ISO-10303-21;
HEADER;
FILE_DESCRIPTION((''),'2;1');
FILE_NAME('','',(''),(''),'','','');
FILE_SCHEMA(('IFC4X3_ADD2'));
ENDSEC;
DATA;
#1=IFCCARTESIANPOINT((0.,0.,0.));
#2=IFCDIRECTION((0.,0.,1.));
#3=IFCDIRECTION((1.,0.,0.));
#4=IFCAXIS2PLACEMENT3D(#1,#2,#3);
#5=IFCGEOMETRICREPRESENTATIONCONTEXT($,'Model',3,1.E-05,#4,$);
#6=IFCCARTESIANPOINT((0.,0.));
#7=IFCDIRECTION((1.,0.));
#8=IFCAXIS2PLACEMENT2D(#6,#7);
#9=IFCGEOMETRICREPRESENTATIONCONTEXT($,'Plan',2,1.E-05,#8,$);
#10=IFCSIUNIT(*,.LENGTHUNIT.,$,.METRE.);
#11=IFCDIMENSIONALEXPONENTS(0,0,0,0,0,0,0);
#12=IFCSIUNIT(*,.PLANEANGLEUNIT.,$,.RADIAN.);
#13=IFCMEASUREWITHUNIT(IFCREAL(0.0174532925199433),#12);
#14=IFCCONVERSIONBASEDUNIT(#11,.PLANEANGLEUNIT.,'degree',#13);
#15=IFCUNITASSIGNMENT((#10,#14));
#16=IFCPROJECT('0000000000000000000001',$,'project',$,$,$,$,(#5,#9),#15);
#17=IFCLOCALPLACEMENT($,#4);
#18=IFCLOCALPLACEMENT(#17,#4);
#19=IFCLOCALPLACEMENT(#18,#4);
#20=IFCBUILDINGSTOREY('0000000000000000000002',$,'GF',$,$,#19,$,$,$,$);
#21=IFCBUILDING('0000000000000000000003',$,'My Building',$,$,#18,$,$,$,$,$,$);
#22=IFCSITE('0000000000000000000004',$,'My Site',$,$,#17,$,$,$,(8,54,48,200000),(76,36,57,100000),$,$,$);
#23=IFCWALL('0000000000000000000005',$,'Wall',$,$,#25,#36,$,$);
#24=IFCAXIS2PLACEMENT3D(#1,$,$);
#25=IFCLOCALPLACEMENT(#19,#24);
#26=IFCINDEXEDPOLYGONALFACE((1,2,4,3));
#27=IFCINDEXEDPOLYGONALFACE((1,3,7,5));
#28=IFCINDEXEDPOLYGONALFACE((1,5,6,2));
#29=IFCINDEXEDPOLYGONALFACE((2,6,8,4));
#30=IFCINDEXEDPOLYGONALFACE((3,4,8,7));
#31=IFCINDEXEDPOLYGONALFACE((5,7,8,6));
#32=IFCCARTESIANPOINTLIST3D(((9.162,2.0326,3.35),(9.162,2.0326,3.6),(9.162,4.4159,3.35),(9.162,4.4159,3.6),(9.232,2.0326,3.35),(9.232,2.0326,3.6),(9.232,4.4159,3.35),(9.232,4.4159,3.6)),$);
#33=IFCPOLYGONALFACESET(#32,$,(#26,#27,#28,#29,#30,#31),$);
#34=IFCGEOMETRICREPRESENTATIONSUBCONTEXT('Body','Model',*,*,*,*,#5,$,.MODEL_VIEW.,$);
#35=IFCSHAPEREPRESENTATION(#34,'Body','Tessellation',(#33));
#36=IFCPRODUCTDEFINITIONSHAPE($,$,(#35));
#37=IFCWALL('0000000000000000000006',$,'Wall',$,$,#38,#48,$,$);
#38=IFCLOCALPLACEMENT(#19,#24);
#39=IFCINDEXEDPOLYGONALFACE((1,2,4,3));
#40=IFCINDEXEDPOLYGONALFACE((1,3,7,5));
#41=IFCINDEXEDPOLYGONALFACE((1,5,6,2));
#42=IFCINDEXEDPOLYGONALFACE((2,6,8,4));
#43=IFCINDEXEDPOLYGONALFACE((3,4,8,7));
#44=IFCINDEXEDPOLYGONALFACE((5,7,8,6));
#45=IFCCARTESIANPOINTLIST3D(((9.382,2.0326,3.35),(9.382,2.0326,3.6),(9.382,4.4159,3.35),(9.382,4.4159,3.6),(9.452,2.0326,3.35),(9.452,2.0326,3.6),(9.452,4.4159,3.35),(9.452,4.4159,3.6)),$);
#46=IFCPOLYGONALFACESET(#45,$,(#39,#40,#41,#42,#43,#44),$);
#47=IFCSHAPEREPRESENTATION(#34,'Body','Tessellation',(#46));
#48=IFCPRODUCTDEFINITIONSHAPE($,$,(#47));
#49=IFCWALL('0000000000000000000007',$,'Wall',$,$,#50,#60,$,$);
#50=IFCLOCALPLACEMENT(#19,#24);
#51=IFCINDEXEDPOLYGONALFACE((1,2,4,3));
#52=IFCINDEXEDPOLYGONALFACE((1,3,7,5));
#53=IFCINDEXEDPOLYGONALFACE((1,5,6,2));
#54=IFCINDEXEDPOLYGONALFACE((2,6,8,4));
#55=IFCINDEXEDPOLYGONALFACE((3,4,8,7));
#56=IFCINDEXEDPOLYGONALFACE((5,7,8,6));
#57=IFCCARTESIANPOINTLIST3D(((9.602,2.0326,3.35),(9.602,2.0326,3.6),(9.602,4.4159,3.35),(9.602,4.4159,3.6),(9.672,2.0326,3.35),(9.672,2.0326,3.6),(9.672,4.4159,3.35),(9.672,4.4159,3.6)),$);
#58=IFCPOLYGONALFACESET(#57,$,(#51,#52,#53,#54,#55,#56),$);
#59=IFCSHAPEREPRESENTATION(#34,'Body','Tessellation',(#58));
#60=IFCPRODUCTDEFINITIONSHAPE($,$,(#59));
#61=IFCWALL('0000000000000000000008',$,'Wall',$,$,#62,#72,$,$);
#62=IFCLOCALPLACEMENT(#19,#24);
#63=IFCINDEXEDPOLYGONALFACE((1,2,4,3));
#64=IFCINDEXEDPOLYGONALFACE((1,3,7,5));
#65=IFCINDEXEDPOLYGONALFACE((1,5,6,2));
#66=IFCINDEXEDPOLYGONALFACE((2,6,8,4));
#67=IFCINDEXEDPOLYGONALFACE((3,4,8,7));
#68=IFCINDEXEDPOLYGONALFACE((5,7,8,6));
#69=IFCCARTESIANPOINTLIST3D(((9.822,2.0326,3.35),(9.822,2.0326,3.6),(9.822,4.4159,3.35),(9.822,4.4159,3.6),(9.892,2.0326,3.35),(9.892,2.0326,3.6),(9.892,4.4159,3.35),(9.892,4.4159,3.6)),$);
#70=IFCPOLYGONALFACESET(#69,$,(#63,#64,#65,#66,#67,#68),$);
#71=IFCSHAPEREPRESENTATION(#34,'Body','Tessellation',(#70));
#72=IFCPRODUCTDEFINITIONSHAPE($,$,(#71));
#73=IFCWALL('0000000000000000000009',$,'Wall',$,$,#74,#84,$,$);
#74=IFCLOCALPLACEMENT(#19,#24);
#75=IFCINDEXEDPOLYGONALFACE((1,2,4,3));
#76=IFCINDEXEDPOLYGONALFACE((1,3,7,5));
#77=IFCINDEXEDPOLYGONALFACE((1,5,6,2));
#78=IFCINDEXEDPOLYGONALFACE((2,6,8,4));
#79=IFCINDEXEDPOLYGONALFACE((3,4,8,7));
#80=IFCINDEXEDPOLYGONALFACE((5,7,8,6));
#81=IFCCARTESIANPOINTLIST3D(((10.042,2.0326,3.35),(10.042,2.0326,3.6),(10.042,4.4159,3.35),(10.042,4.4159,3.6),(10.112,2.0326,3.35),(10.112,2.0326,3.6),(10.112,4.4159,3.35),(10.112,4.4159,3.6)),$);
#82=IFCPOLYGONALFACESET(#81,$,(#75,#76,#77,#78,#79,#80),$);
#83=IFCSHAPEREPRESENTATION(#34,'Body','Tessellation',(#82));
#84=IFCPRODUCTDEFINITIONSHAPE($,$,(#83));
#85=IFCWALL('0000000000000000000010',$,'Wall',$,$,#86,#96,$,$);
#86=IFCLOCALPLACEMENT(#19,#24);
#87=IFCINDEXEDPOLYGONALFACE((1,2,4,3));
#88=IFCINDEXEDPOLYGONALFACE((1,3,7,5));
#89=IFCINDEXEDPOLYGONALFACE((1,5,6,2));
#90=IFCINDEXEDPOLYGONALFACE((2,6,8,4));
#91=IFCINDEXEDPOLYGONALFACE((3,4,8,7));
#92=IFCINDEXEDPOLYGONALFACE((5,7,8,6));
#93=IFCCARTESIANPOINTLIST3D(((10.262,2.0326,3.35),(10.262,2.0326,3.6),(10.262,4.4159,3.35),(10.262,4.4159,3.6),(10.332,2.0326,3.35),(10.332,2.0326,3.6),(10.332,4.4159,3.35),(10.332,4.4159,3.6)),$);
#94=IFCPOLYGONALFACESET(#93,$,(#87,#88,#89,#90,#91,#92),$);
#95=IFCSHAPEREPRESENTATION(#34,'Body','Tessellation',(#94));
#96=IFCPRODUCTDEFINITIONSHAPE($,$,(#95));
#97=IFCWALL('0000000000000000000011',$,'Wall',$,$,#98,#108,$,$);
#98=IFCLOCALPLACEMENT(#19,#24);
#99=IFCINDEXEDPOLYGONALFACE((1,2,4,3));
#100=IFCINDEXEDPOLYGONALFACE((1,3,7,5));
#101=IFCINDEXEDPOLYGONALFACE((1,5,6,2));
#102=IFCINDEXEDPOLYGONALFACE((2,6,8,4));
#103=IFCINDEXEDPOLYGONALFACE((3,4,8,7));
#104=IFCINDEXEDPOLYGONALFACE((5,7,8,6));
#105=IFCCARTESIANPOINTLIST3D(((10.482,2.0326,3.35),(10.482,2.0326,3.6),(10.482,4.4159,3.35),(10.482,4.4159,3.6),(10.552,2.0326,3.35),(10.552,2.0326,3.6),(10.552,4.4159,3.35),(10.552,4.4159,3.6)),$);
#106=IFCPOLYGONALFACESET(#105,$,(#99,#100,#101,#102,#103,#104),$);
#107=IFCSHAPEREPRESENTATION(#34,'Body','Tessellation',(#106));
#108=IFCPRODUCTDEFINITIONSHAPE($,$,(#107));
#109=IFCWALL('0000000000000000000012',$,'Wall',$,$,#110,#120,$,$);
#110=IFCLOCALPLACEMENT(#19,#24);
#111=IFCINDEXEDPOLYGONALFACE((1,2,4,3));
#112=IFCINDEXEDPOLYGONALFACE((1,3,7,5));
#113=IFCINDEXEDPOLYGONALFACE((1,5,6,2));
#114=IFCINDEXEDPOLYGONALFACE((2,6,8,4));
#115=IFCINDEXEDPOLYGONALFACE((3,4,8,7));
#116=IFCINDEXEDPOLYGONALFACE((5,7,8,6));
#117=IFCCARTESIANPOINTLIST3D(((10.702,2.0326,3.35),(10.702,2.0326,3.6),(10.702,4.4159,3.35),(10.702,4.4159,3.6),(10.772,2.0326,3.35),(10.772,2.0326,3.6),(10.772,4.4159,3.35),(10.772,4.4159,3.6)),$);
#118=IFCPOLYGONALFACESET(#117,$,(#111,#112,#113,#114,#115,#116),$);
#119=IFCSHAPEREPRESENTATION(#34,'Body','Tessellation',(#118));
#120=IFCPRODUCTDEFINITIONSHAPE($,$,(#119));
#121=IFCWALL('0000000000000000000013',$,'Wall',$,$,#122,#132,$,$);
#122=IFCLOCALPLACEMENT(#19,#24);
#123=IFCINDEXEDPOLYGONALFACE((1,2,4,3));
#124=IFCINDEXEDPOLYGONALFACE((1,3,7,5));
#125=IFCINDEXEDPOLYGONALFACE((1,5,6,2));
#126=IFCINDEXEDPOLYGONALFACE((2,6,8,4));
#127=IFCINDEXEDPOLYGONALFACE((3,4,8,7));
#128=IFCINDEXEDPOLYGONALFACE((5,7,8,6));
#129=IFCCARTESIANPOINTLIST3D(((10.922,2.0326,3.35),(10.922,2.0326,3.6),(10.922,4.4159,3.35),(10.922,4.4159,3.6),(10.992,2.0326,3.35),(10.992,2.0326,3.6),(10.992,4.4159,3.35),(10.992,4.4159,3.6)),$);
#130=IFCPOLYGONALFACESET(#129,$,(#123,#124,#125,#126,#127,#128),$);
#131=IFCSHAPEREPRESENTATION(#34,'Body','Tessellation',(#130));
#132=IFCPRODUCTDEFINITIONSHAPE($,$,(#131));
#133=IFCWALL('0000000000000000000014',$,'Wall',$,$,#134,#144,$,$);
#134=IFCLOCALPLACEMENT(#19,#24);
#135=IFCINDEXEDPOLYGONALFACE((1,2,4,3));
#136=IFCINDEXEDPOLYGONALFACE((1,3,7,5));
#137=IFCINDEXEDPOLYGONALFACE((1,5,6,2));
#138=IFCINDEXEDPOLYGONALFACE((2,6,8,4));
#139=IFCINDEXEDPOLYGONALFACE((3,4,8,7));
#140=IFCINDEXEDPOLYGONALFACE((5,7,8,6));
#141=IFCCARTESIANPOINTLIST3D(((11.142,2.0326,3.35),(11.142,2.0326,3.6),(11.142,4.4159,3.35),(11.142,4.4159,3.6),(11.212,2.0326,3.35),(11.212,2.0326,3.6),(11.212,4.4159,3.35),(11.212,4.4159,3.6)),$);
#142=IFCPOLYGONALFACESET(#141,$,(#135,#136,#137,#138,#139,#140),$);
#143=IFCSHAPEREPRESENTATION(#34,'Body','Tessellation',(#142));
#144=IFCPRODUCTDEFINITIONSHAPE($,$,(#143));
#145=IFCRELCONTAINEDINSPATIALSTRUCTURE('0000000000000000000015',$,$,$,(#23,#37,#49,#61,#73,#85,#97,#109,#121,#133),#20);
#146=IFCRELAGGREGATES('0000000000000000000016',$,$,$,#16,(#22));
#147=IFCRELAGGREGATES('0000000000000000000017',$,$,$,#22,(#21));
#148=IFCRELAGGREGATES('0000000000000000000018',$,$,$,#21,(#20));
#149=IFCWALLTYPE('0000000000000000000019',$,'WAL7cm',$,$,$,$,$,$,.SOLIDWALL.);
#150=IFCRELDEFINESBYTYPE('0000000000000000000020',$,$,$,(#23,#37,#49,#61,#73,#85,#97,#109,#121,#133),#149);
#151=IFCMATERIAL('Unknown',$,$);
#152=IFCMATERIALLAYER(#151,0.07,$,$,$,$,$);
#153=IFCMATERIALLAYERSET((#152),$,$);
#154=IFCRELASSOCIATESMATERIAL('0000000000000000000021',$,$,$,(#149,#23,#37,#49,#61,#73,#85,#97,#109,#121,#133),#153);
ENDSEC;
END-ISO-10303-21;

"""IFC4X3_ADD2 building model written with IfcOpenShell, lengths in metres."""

from ifc_helpers import new_model, entity, si_unit, converted_unit, frame, origin_with_axes, origin_2d_with_axis, place, context, subcontext, project, spatial, line, indexed_curve, outline, extrude, material, layer, layer_set, layer_usage, type_object, element, save


model = new_model("IFC4X3_ADD2")

# Units and contexts
model_context = context("Model", 3, precision=1e-05, world=origin_with_axes())
plan_context = context("Plan", 2, precision=1e-05, world=origin_2d_with_axis())
body_context = subcontext(model_context, "Body", "Model", "MODEL_VIEW")
ifc_project = project(units=[si_unit("LENGTHUNIT", "METRE"), converted_unit("PLANEANGLEUNIT", "degree", entity("IfcReal", 0.0174532925199433), si_unit("PLANEANGLEUNIT", "RADIAN"), dimensions=[0, 0, 0, 0, 0, 0, 0])], contexts=[model_context, plan_context])

# Site, building, storey
site_placement = place(None, origin_with_axes())
site = spatial("IfcSite", under=ifc_project, at=site_placement, Name="My Site", RefLatitude=(8, 54, 48, 200000), RefLongitude=(76, 36, 57, 100000))
building_placement = place(site_placement, origin_with_axes())
building = spatial("IfcBuilding", under=site, at=building_placement, Name="My Building")
storey_placement = place(building_placement, origin_with_axes())
storey = spatial("IfcBuildingStorey", under=building, at=storey_placement, Name="GF")

# Walls
ifc_material_1 = material(Name="Unknown")
ifc_layer_1 = layer(ifc_material_1, 0.07)
ifc_layer_set_1 = layer_set([ifc_layer_1])
wall_type_1 = type_object("IfcWallType", Name="WAL7cm", PredefinedType="SOLIDWALL", material=ifc_layer_set_1)
ifc_layer_usage_1 = layer_usage(ifc_layer_set_1, "AXIS2", "NEGATIVE", 0.0)
wall_1_placement = place(storey_placement, frame((9.232, 4.4159, 3.35), z_axis=(0.0, 0.0, 1.0), x_axis=(0.0, -1.0, 0.0)))
element("IfcWall", 1, at=wall_1_placement, inside=storey, type_object=wall_type_1, material=ifc_layer_usage_1, Name="Wall", context=body_context, shape_type="SweptSolid", body=[
    extrude(outline(indexed_curve([(0.0, -0.07), (0.0, 0.0), (2.3833, 0.0), (2.3833, -0.07)], segments=[line(1, 2, 3, 4, 1)])), origin_with_axes(), (0.0, 0.0, 1.0), 0.25),
])
ifc_layer_usage_2 = layer_usage(ifc_layer_set_1, "AXIS2", "NEGATIVE", 0.0)
wall_2_placement = place(storey_placement, frame((9.452, 4.4159, 3.35), z_axis=(0.0, 0.0, 1.0), x_axis=(0.0, -1.0, 0.0)))
element("IfcWall", 2, at=wall_2_placement, inside=storey, type_object=wall_type_1, material=ifc_layer_usage_2, Name="Wall", context=body_context, shape_type="SweptSolid", body=[
    extrude(outline(indexed_curve([(0.0, -0.07), (0.0, 0.0), (2.3833, 0.0), (2.3833, -0.07)], segments=[line(1, 2, 3, 4, 1)])), origin_with_axes(), (0.0, 0.0, 1.0), 0.25),
])
ifc_layer_usage_3 = layer_usage(ifc_layer_set_1, "AXIS2", "NEGATIVE", 0.0)
wall_3_placement = place(storey_placement, frame((9.672, 4.4159, 3.35), z_axis=(0.0, 0.0, 1.0), x_axis=(0.0, -1.0, 0.0)))
element("IfcWall", 3, at=wall_3_placement, inside=storey, type_object=wall_type_1, material=ifc_layer_usage_3, Name="Wall", context=body_context, shape_type="SweptSolid", body=[
    extrude(outline(indexed_curve([(0.0, -0.07), (0.0, 0.0), (2.3833, 0.0), (2.3833, -0.07)], segments=[line(1, 2, 3, 4, 1)])), origin_with_axes(), (0.0, 0.0, 1.0), 0.25),
])
ifc_layer_usage_4 = layer_usage(ifc_layer_set_1, "AXIS2", "NEGATIVE", 0.0)
wall_4_placement = place(storey_placement, frame((9.892, 4.4159, 3.35), z_axis=(0.0, 0.0, 1.0), x_axis=(0.0, -1.0, 0.0)))
element("IfcWall", 4, at=wall_4_placement, inside=storey, type_object=wall_type_1, material=ifc_layer_usage_4, Name="Wall", context=body_context, shape_type="SweptSolid", body=[
    extrude(outline(indexed_curve([(0.0, -0.07), (0.0, 0.0), (2.3833, 0.0), (2.3833, -0.07)], segments=[line(1, 2, 3, 4, 1)])), origin_with_axes(), (0.0, 0.0, 1.0), 0.25),
])
ifc_layer_usage_5 = layer_usage(ifc_layer_set_1, "AXIS2", "NEGATIVE", 0.0)
wall_5_placement = place(storey_placement, frame((10.112, 4.4159, 3.35), z_axis=(0.0, 0.0, 1.0), x_axis=(0.0, -1.0, 0.0)))
element("IfcWall", 5, at=wall_5_placement, inside=storey, type_object=wall_type_1, material=ifc_layer_usage_5, Name="Wall", context=body_context, shape_type="SweptSolid", body=[
    extrude(outline(indexed_curve([(0.0, -0.07), (0.0, 0.0), (2.3833, 0.0), (2.3833, -0.07)], segments=[line(1, 2, 3, 4, 1)])), origin_with_axes(), (0.0, 0.0, 1.0), 0.25),
])
ifc_layer_usage_6 = layer_usage(ifc_layer_set_1, "AXIS2", "NEGATIVE", 0.0)
wall_6_placement = place(storey_placement, frame((10.332, 4.4159, 3.35), z_axis=(0.0, 0.0, 1.0), x_axis=(0.0, -1.0, 0.0)))
element("IfcWall", 6, at=wall_6_placement, inside=storey, type_object=wall_type_1, material=ifc_layer_usage_6, Name="Wall", context=body_context, shape_type="SweptSolid", body=[
    extrude(outline(indexed_curve([(0.0, -0.07), (0.0, 0.0), (2.3833, 0.0), (2.3833, -0.07)], segments=[line(1, 2, 3, 4, 1)])), origin_with_axes(), (0.0, 0.0, 1.0), 0.25),
])
ifc_layer_usage_7 = layer_usage(ifc_layer_set_1, "AXIS2", "NEGATIVE", 0.0)
wall_7_placement = place(storey_placement, frame((10.552, 4.4159, 3.35), z_axis=(0.0, 0.0, 1.0), x_axis=(0.0, -1.0, 0.0)))
element("IfcWall", 7, at=wall_7_placement, inside=storey, type_object=wall_type_1, material=ifc_layer_usage_7, Name="Wall", context=body_context, shape_type="SweptSolid", body=[
    extrude(outline(indexed_curve([(0.0, -0.07), (0.0, 0.0), (2.3833, 0.0), (2.3833, -0.07)], segments=[line(1, 2, 3, 4, 1)])), origin_with_axes(), (0.0, 0.0, 1.0), 0.25),
])
ifc_layer_usage_8 = layer_usage(ifc_layer_set_1, "AXIS2", "NEGATIVE", 0.0)
wall_8_placement = place(storey_placement, frame((10.772, 4.4159, 3.35), z_axis=(0.0, 0.0, 1.0), x_axis=(0.0, -1.0, 0.0)))
element("IfcWall", 8, at=wall_8_placement, inside=storey, type_object=wall_type_1, material=ifc_layer_usage_8, Name="Wall", context=body_context, shape_type="SweptSolid", body=[
    extrude(outline(indexed_curve([(0.0, -0.07), (0.0, 0.0), (2.3833, 0.0), (2.3833, -0.07)], segments=[line(1, 2, 3, 4, 1)])), origin_with_axes(), (0.0, 0.0, 1.0), 0.25),
])
ifc_layer_usage_9 = layer_usage(ifc_layer_set_1, "AXIS2", "NEGATIVE", 0.0)
wall_9_placement = place(storey_placement, frame((10.992, 4.4159, 3.35), z_axis=(0.0, 0.0, 1.0), x_axis=(0.0, -1.0, 0.0)))
element("IfcWall", 9, at=wall_9_placement, inside=storey, type_object=wall_type_1, material=ifc_layer_usage_9, Name="Wall", context=body_context, shape_type="SweptSolid", body=[
    extrude(outline(indexed_curve([(0.0, -0.07), (0.0, 0.0), (2.3833, 0.0), (2.3833, -0.07)], segments=[line(1, 2, 3, 4, 1)])), origin_with_axes(), (0.0, 0.0, 1.0), 0.25),
])
ifc_layer_usage_10 = layer_usage(ifc_layer_set_1, "AXIS2", "NEGATIVE", 0.0)
wall_10_placement = place(storey_placement, frame((11.212, 4.4159, 3.35), z_axis=(0.0, 0.0, 1.0), x_axis=(0.0, -1.0, 0.0)))
element("IfcWall", 10, at=wall_10_placement, inside=storey, type_object=wall_type_1, material=ifc_layer_usage_10, Name="Wall", context=body_context, shape_type="SweptSolid", body=[
    extrude(outline(indexed_curve([(0.0, -0.07), (0.0, 0.0), (2.3833, 0.0), (2.3833, -0.07)], segments=[line(1, 2, 3, 4, 1)])), origin_with_axes(), (0.0, 0.0, 1.0), 0.25),
])

save(model, "model.ifc")
